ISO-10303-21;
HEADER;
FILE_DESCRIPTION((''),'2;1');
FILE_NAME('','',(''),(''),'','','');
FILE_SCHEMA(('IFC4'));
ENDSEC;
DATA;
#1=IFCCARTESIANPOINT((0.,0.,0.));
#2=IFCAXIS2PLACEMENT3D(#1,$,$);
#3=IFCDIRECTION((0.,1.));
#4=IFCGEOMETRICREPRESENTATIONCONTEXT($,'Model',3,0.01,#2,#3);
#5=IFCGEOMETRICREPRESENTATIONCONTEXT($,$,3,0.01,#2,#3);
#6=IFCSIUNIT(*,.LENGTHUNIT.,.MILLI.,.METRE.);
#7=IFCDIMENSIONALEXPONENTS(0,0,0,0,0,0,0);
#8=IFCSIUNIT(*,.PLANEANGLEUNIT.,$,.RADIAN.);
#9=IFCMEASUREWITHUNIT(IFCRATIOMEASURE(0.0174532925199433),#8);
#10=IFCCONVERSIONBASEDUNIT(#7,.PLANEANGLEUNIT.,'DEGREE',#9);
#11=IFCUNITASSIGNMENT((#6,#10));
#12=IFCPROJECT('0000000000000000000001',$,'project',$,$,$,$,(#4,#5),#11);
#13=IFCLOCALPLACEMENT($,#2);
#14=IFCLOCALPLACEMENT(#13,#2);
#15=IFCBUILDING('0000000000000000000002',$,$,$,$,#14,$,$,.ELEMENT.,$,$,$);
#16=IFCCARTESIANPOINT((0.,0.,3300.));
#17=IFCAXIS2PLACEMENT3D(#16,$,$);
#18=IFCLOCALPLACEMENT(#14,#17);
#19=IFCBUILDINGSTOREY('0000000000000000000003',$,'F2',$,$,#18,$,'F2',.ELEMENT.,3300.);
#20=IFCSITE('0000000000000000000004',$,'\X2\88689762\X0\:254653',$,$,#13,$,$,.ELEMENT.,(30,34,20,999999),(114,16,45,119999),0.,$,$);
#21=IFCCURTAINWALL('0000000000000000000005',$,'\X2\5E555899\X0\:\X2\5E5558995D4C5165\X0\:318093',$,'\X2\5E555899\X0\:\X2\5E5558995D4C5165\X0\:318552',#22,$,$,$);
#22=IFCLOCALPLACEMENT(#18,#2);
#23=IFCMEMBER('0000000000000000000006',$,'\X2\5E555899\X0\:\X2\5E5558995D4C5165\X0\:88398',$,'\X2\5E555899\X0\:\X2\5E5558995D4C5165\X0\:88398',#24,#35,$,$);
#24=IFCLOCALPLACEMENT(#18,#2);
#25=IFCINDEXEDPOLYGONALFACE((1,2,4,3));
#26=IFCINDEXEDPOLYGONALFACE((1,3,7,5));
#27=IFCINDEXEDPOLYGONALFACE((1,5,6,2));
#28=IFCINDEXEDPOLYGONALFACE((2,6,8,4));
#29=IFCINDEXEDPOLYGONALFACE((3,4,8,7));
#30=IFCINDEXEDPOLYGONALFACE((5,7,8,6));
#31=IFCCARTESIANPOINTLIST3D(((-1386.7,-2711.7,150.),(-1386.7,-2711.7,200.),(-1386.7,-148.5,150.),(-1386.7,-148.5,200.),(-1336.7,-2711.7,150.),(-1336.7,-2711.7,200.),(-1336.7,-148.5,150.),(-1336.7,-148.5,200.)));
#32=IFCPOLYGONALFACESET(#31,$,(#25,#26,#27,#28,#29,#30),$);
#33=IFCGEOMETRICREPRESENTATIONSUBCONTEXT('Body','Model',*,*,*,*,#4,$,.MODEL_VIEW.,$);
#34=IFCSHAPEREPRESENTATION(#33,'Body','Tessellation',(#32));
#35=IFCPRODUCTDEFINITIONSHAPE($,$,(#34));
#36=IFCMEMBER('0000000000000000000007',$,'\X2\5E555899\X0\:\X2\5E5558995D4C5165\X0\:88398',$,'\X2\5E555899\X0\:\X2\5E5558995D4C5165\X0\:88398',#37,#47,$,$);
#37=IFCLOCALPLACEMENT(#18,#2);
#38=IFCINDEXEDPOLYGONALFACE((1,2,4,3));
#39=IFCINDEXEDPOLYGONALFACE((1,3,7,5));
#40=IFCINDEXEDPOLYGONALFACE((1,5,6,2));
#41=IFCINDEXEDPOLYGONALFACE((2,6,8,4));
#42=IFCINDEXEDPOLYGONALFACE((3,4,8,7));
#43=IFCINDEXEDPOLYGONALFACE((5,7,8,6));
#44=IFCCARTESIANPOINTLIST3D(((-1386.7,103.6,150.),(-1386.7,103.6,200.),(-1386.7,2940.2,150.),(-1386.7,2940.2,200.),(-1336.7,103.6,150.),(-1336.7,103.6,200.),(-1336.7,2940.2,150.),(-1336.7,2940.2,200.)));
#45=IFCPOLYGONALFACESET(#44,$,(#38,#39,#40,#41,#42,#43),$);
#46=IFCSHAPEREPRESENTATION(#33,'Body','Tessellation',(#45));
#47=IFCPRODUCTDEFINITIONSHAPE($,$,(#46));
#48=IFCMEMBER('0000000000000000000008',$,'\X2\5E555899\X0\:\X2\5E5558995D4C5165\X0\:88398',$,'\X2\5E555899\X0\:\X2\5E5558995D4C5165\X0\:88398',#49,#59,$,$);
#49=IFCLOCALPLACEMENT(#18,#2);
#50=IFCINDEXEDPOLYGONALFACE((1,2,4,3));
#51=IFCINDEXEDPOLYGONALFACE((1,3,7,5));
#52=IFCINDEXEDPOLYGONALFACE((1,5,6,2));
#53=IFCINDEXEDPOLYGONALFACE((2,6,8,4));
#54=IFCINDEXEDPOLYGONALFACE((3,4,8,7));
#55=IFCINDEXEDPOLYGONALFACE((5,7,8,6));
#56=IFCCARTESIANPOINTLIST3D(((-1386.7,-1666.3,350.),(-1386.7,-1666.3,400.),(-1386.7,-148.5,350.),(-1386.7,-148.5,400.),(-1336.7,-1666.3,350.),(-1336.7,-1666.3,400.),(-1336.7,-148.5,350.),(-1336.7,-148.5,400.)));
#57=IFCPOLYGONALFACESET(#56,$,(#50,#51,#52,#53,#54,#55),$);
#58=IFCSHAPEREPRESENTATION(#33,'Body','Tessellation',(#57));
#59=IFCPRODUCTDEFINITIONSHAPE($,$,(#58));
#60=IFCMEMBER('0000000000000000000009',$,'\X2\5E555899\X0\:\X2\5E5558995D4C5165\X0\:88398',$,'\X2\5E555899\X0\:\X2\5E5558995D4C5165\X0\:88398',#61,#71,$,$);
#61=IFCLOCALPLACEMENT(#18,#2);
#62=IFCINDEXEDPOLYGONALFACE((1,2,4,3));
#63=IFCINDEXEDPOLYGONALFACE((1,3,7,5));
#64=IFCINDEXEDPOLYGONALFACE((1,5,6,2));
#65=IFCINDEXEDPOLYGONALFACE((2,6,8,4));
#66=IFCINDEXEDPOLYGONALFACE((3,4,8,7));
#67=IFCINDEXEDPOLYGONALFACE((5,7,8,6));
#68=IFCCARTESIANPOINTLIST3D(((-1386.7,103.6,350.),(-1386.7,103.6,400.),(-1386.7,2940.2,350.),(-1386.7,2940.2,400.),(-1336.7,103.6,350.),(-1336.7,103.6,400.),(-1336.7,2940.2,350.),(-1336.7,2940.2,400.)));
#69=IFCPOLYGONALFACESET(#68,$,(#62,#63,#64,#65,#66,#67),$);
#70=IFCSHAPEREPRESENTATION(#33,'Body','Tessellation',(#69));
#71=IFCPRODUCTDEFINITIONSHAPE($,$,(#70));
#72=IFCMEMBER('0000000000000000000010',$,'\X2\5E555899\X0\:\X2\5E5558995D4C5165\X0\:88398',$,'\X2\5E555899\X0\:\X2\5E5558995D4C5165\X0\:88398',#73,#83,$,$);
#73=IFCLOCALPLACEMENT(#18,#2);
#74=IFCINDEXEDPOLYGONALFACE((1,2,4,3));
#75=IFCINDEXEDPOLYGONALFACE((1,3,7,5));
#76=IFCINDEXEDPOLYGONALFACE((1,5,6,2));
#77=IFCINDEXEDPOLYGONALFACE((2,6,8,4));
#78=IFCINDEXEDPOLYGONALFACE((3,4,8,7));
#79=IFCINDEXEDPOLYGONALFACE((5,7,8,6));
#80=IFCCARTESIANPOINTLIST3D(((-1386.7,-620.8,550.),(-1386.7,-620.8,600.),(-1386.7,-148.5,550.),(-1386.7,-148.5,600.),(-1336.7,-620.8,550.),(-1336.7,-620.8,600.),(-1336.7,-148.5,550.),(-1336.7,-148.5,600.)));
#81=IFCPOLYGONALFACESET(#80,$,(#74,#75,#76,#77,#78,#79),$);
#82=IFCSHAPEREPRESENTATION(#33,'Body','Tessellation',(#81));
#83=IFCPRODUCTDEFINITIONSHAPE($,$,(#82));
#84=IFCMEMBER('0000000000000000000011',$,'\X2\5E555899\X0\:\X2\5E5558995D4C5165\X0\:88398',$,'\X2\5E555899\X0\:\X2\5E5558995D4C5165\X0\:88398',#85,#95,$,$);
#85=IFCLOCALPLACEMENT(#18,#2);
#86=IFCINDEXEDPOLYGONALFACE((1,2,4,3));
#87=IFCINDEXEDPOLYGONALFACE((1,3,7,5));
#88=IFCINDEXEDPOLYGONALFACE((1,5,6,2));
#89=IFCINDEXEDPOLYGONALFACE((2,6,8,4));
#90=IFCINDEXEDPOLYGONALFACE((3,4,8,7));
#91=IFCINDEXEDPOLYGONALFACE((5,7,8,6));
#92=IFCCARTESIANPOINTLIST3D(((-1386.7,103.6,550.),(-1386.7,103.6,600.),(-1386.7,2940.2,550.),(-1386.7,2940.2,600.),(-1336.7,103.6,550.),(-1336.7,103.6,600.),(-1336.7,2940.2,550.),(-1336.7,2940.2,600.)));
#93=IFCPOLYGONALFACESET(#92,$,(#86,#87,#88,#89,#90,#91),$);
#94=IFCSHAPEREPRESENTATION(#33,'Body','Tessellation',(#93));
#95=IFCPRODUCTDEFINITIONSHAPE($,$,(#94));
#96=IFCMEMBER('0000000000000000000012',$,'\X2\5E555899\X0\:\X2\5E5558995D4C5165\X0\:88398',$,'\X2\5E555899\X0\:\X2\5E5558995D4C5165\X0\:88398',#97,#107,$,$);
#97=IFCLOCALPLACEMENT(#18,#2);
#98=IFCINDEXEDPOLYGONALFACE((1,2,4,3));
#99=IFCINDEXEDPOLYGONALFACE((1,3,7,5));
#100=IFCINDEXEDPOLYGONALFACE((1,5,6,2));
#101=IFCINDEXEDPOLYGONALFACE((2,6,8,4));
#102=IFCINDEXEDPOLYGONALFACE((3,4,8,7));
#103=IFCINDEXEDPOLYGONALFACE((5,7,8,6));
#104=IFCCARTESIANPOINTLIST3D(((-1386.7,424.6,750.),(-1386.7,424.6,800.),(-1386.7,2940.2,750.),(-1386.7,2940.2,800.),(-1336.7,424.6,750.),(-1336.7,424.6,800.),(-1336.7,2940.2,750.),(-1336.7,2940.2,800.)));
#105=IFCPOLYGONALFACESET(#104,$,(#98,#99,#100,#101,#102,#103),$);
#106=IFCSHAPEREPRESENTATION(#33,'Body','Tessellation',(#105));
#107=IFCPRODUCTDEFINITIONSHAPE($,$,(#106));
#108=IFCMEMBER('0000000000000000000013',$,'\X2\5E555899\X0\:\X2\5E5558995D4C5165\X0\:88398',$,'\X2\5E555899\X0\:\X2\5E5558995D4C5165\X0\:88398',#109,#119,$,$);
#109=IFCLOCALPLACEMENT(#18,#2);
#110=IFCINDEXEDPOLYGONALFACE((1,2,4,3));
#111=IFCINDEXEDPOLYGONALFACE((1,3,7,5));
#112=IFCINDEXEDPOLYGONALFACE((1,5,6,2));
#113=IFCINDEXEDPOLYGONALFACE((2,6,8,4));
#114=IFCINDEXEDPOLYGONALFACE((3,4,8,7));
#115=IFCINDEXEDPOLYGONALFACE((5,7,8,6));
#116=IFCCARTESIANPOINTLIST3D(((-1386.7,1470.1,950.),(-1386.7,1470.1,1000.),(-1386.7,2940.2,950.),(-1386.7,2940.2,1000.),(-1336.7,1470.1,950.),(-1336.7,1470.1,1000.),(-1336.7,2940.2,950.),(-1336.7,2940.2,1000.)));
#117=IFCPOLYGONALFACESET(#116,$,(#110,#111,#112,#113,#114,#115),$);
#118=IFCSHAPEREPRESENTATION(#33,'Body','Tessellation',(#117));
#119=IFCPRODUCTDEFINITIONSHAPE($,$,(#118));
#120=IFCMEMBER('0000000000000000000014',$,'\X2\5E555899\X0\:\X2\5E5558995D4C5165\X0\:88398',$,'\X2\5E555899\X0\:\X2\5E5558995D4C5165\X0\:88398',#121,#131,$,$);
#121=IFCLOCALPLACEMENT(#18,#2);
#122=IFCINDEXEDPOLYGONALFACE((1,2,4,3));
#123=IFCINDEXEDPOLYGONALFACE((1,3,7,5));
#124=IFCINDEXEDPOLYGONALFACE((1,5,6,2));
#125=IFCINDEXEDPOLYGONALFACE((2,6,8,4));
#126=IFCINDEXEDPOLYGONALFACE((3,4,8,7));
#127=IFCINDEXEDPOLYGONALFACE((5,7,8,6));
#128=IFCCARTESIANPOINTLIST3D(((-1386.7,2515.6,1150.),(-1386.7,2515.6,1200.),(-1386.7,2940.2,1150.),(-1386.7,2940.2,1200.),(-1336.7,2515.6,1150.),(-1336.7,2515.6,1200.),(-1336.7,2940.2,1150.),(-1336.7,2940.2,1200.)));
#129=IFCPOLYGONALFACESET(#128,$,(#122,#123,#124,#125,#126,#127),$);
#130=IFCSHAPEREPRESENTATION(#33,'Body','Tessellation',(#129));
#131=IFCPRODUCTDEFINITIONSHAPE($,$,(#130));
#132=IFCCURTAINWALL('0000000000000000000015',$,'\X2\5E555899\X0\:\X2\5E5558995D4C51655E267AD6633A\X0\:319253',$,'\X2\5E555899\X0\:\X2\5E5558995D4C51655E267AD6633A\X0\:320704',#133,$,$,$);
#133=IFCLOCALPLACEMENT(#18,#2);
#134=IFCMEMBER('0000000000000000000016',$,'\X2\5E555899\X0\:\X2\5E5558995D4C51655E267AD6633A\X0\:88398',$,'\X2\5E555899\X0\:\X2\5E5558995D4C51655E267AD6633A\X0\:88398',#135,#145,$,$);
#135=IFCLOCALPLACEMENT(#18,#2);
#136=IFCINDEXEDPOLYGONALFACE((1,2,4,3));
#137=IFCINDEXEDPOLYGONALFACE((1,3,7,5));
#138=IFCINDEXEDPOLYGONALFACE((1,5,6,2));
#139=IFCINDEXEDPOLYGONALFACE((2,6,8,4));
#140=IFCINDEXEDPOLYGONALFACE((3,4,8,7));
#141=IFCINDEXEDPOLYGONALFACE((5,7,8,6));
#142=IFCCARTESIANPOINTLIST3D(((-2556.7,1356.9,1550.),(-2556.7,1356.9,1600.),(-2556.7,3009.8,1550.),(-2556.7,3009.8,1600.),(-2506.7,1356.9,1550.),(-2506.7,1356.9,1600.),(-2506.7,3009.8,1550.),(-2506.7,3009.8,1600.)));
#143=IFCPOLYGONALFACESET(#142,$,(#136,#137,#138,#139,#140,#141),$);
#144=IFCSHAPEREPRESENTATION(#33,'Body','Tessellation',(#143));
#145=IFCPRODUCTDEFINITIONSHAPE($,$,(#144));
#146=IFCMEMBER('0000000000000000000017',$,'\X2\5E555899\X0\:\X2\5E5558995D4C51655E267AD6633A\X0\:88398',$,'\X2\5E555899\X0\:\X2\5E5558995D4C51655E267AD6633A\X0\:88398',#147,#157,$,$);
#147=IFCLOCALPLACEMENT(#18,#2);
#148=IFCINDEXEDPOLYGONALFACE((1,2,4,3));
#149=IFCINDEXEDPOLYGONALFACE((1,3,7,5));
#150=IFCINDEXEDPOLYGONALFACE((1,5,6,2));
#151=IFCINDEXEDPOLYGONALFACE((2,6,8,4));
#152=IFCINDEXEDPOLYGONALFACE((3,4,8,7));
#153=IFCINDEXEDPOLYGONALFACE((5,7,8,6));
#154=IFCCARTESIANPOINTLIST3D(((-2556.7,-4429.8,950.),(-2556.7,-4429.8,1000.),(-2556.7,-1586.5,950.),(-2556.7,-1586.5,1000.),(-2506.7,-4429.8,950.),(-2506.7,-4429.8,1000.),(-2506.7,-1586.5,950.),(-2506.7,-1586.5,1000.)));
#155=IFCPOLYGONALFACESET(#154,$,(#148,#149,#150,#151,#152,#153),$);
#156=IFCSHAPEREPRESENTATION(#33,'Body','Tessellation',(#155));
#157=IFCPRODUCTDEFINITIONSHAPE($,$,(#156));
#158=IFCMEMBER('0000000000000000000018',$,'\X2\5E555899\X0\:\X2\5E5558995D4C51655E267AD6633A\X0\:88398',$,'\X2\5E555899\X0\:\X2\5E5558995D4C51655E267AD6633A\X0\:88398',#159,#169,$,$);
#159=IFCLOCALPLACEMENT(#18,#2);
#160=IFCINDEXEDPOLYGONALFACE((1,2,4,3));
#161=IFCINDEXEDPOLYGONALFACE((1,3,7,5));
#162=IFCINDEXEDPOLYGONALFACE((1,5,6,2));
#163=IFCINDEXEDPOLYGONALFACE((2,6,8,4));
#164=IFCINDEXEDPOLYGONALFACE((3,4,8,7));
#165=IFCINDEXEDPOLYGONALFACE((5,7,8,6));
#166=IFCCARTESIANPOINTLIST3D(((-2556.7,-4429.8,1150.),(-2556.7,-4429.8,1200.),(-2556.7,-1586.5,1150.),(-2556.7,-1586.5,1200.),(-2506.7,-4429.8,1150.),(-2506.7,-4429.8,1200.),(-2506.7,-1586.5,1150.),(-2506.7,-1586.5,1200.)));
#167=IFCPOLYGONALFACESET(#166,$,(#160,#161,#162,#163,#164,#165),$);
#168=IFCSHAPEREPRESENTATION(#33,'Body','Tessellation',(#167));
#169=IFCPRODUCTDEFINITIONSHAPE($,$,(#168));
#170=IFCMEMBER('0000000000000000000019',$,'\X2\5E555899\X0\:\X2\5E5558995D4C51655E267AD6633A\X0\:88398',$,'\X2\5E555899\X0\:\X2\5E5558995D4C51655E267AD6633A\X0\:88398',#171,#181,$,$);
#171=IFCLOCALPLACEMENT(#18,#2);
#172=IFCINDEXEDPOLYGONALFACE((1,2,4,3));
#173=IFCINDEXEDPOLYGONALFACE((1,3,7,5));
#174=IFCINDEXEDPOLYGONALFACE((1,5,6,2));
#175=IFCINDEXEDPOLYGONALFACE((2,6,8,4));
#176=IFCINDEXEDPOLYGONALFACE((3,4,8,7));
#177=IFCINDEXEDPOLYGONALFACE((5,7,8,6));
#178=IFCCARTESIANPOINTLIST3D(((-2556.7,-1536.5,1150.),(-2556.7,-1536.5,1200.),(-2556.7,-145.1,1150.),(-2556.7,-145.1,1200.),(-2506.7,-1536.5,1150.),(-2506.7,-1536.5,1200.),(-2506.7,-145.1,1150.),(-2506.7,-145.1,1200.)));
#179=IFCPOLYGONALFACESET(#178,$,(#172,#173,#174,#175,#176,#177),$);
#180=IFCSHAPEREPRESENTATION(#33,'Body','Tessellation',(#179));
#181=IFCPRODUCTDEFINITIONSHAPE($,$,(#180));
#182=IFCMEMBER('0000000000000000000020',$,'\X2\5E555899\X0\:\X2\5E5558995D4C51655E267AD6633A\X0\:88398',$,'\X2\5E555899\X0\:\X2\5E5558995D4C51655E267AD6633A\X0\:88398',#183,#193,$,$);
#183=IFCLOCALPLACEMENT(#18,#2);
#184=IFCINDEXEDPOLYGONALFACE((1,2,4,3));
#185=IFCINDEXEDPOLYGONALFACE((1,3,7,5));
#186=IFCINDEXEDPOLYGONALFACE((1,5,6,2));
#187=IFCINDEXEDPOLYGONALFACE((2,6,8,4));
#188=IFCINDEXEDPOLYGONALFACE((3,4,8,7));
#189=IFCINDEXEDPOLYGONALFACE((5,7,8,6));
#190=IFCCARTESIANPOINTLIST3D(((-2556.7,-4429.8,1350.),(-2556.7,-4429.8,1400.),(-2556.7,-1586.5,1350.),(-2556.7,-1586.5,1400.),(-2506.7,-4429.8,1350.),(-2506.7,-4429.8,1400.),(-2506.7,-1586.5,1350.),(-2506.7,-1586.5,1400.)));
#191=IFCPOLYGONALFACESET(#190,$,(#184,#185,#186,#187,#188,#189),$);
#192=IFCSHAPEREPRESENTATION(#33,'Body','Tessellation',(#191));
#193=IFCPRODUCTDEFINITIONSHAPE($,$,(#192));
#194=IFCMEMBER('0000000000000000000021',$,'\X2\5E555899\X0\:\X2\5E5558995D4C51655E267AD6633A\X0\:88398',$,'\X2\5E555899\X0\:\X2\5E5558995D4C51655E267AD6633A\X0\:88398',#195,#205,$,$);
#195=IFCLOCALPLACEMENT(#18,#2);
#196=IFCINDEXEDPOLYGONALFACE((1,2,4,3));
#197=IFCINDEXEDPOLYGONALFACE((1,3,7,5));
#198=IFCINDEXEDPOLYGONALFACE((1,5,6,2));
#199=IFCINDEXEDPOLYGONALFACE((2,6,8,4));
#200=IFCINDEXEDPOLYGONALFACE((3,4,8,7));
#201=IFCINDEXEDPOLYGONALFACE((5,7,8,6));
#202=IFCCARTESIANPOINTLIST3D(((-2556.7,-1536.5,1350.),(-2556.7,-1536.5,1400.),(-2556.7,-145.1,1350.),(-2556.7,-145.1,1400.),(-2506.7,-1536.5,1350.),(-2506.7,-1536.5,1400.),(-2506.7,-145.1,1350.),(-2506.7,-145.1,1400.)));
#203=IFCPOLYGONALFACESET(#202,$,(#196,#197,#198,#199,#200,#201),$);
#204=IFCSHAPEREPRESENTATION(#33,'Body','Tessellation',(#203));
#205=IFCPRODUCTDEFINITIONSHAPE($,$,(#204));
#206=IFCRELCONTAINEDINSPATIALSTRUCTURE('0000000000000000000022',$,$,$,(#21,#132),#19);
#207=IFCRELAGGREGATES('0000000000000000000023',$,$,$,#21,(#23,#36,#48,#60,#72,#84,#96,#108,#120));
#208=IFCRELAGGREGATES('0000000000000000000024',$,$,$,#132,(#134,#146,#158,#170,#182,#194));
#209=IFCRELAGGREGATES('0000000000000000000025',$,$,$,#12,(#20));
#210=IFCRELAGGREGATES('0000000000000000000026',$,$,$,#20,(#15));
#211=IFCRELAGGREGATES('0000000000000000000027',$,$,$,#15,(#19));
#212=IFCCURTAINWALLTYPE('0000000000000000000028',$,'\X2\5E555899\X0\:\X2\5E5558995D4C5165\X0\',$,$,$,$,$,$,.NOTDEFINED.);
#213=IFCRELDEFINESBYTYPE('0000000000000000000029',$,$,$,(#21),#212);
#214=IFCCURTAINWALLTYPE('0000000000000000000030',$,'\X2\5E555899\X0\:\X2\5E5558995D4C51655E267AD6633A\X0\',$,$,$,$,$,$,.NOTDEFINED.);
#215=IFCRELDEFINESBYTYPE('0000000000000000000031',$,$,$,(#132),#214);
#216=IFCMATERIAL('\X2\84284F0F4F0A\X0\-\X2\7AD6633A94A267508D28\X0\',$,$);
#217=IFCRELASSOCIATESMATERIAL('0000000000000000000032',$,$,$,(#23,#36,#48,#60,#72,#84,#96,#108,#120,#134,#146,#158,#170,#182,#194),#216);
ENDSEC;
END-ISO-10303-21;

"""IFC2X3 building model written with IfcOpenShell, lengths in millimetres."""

from ifc_helpers import new_model, entity, si_unit, converted_unit, direction, frame, frame_2d, origin, origin_2d_with_axis, place, context, subcontext, project, spatial, rectangle, extrude, material, type_object, element, aggregate, save


model = new_model("IFC2X3")

# Units and contexts
model_context = context("Model", 3, precision=0.01, world=origin(), true_north=direction((0.0, 1.0)))
context_of_model = context(None, 3, precision=0.01, world=origin(), true_north=direction((0.0, 1.0)))
body_context = subcontext(model_context, "Body", "Model", "MODEL_VIEW")
ifc_project = project(units=[si_unit("LENGTHUNIT", "METRE", prefix="MILLI"), converted_unit("PLANEANGLEUNIT", "DEGREE", entity("IfcRatioMeasure", 0.0174532925199433), si_unit("PLANEANGLEUNIT", "RADIAN"), dimensions=[0, 0, 0, 0, 0, 0, 0])], contexts=[model_context, context_of_model])

# Site, building, storey
site_placement = place(None, origin())
site = spatial("IfcSite", under=ifc_project, at=site_placement, Name="表面:254653", CompositionType="ELEMENT", RefLatitude=(30, 34, 20, 999999), RefLongitude=(114, 16, 45, 119999), RefElevation=0.0)
building_placement = place(site_placement, origin())
building = spatial("IfcBuilding", under=site, at=building_placement, CompositionType="ELEMENT")
storey_placement = place(building_placement, frame((0.0, 0.0, 3300.0)))
storey = spatial("IfcBuildingStorey", under=building, at=storey_placement, Name="F2", LongName="F2", CompositionType="ELEMENT", Elevation=3300.0)

# Curtain wall, members
curtain_wall_type_1 = type_object("IfcCurtainWallType", Name="幕墙:幕墙嵌入", PredefinedType="NOTDEFINED")
curtain_wall_1_placement = place(storey_placement, frame((0.0, 0.0, -3300.0)))
curtain_wall_1 = element("IfcCurtainWall", 1, at=curtain_wall_1_placement, inside=storey, type_object=curtain_wall_type_1, Name="幕墙:幕墙嵌入:318093", ObjectType="幕墙:幕墙嵌入:318552")
ifc_material_1 = material(Name="萨伏伊-竖挺钢材质")
member_1_placement = place(curtain_wall_1_placement, frame((0.0, 0.0, 3300.0)))
member_1 = element("IfcMember", 2, at=member_1_placement, material=ifc_material_1, Name="幕墙:幕墙嵌入:88398", ObjectType="幕墙:幕墙嵌入:88398", context=body_context, shape_type="SweptSolid", body=[
    extrude(rectangle(XDim=50.0, YDim=50.0, at=origin_2d_with_axis()), frame((-1361.7, -2711.7, 175.0), z_axis=(0.0, 1.0, 0.0), x_axis=(0.0, 0.0, -1.0)), (0.0, 0.0, 1.0), 2563.2),
])
member_2_placement = place(curtain_wall_1_placement, frame((0.0, 0.0, 3300.0)))
member_2 = element("IfcMember", 3, at=member_2_placement, material=ifc_material_1, Name="幕墙:幕墙嵌入:88398", ObjectType="幕墙:幕墙嵌入:88398", context=body_context, shape_type="SweptSolid", body=[
    extrude(rectangle(XDim=50.0, YDim=50.0, at=origin_2d_with_axis()), frame((-1361.7, 103.6, 175.0), z_axis=(0.0, 1.0, 0.0), x_axis=(0.0, 0.0, -1.0)), (0.0, 0.0, 1.0), 2836.6),
])
member_3_placement = place(curtain_wall_1_placement, frame((0.0, 0.0, 3300.0)))
member_3 = element("IfcMember", 4, at=member_3_placement, material=ifc_material_1, Name="幕墙:幕墙嵌入:88398", ObjectType="幕墙:幕墙嵌入:88398", context=body_context, shape_type="SweptSolid", body=[
    extrude(rectangle(XDim=50.0, YDim=50.0, at=origin_2d_with_axis()), frame((-1361.7, -1666.3, 375.0), z_axis=(0.0, 1.0, 0.0), x_axis=(0.0, 0.0, -1.0)), (0.0, 0.0, 1.0), 1517.7),
])
member_4_placement = place(curtain_wall_1_placement, frame((0.0, 0.0, 3300.0)))
member_4 = element("IfcMember", 5, at=member_4_placement, material=ifc_material_1, Name="幕墙:幕墙嵌入:88398", ObjectType="幕墙:幕墙嵌入:88398", context=body_context, shape_type="SweptSolid", body=[
    extrude(rectangle(XDim=50.0, YDim=50.0, at=origin_2d_with_axis()), frame((-1361.7, 103.6, 375.0), z_axis=(0.0, 1.0, 0.0), x_axis=(0.0, 0.0, -1.0)), (0.0, 0.0, 1.0), 2836.6),
])
member_5_placement = place(curtain_wall_1_placement, frame((0.0, 0.0, 3300.0)))
member_5 = element("IfcMember", 6, at=member_5_placement, material=ifc_material_1, Name="幕墙:幕墙嵌入:88398", ObjectType="幕墙:幕墙嵌入:88398", context=body_context, shape_type="SweptSolid", body=[
    extrude(rectangle(XDim=50.0, YDim=50.0, at=origin_2d_with_axis()), frame((-1361.7, -620.8, 575.0), z_axis=(0.0, 1.0, 0.0), x_axis=(0.0, 0.0, -1.0)), (0.0, 0.0, 1.0), 472.3),
])
member_6_placement = place(curtain_wall_1_placement, frame((0.0, 0.0, 3300.0)))
member_6 = element("IfcMember", 7, at=member_6_placement, material=ifc_material_1, Name="幕墙:幕墙嵌入:88398", ObjectType="幕墙:幕墙嵌入:88398", context=body_context, shape_type="SweptSolid", body=[
    extrude(rectangle(XDim=50.0, YDim=50.0, at=origin_2d_with_axis()), frame((-1361.7, 103.6, 575.0), z_axis=(0.0, 1.0, 0.0), x_axis=(0.0, 0.0, -1.0)), (0.0, 0.0, 1.0), 2836.6),
])
member_7_placement = place(curtain_wall_1_placement, frame((0.0, 0.0, 3300.0)))
member_7 = element("IfcMember", 8, at=member_7_placement, material=ifc_material_1, Name="幕墙:幕墙嵌入:88398", ObjectType="幕墙:幕墙嵌入:88398", context=body_context, shape_type="SweptSolid", body=[
    extrude(rectangle(XDim=50.0, YDim=50.0, at=origin_2d_with_axis()), frame((-1361.7, 424.6, 775.0), z_axis=(0.0, 1.0, 0.0), x_axis=(0.0, 0.0, -1.0)), (0.0, 0.0, 1.0), 2515.6),
])
member_8_placement = place(curtain_wall_1_placement, frame((0.0, 0.0, 3300.0)))
member_8 = element("IfcMember", 9, at=member_8_placement, material=ifc_material_1, Name="幕墙:幕墙嵌入:88398", ObjectType="幕墙:幕墙嵌入:88398", context=body_context, shape_type="SweptSolid", body=[
    extrude(rectangle(XDim=50.0, YDim=50.0, at=origin_2d_with_axis()), frame((-1361.7, 1470.1, 975.0), z_axis=(0.0, 1.0, 0.0), x_axis=(0.0, 0.0, -1.0)), (0.0, 0.0, 1.0), 1470.1),
])
member_9_placement = place(curtain_wall_1_placement, frame((0.0, 0.0, 3300.0)))
member_9 = element("IfcMember", 10, at=member_9_placement, material=ifc_material_1, Name="幕墙:幕墙嵌入:88398", ObjectType="幕墙:幕墙嵌入:88398", context=body_context, shape_type="SweptSolid", body=[
    extrude(rectangle(XDim=50.0, YDim=50.0, at=origin_2d_with_axis()), frame((-1361.7, 2515.6, 1175.0), z_axis=(0.0, 1.0, 0.0), x_axis=(0.0, 0.0, -1.0)), (0.0, 0.0, 1.0), 424.6),
])
aggregate(curtain_wall_1, [member_1, member_2, member_3, member_4, member_5, member_6, member_7, member_8, member_9])

# Curtain wall, members
curtain_wall_type_2 = type_object("IfcCurtainWallType", Name="幕墙:幕墙嵌入带竖挺", PredefinedType="NOTDEFINED")
curtain_wall_2_placement = place(storey_placement, frame((0.0, 0.0, -3300.0)))
curtain_wall_2 = element("IfcCurtainWall", 11, at=curtain_wall_2_placement, inside=storey, type_object=curtain_wall_type_2, Name="幕墙:幕墙嵌入带竖挺:319253", ObjectType="幕墙:幕墙嵌入带竖挺:320704")
member_10_placement = place(curtain_wall_2_placement, frame((0.0, 0.0, 3300.0)))
member_10 = element("IfcMember", 12, at=member_10_placement, material=ifc_material_1, Name="幕墙:幕墙嵌入带竖挺:88398", ObjectType="幕墙:幕墙嵌入带竖挺:88398", context=body_context, shape_type="SweptSolid", body=[
    extrude(rectangle(XDim=50.0, YDim=50.0, at=origin_2d_with_axis()), frame((-2531.7, 1356.9, 1575.0), z_axis=(0.0, 1.0, 0.0), x_axis=(0.0, 0.0, -1.0)), (0.0, 0.0, 1.0), 1653.0),
])
member_11_placement = place(curtain_wall_2_placement, frame((0.0, 0.0, 3300.0)))
member_11 = element("IfcMember", 13, at=member_11_placement, material=ifc_material_1, Name="幕墙:幕墙嵌入带竖挺:88398", ObjectType="幕墙:幕墙嵌入带竖挺:88398", context=body_context, shape_type="SweptSolid", body=[
    extrude(rectangle(XDim=50.0, YDim=50.0, at=origin_2d_with_axis()), frame((-2531.7, -4429.8, 975.0), z_axis=(0.0, 1.0, 0.0), x_axis=(0.0, 0.0, -1.0)), (0.0, 0.0, 1.0), 2843.3),
])
member_12_placement = place(curtain_wall_2_placement, frame((0.0, 0.0, 3300.0)))
member_12 = element("IfcMember", 14, at=member_12_placement, material=ifc_material_1, Name="幕墙:幕墙嵌入带竖挺:88398", ObjectType="幕墙:幕墙嵌入带竖挺:88398", context=body_context, shape_type="SweptSolid", body=[
    extrude(rectangle(XDim=50.0, YDim=50.0, at=origin_2d_with_axis()), frame((-2531.7, -4429.8, 1175.0), z_axis=(0.0, 1.0, 0.0), x_axis=(0.0, 0.0, -1.0)), (0.0, 0.0, 1.0), 2843.3),
])
member_13_placement = place(curtain_wall_2_placement, frame((0.0, 0.0, 3300.0)))
member_13 = element("IfcMember", 15, at=member_13_placement, material=ifc_material_1, Name="幕墙:幕墙嵌入带竖挺:88398", ObjectType="幕墙:幕墙嵌入带竖挺:88398", context=body_context, shape_type="SweptSolid", body=[
    extrude(rectangle(XDim=50.0, YDim=50.0, at=frame_2d((0.0, 0.0), x_axis=(1.0, 0.0))), frame((-2531.7, -1536.5, 1175.0), z_axis=(0.0, 1.0, 0.0), x_axis=(0.0, 0.0, -1.0)), (0.0, 0.0, 1.0), 1391.3),
])
member_14_placement = place(curtain_wall_2_placement, frame((0.0, 0.0, 3300.0)))
member_14 = element("IfcMember", 16, at=member_14_placement, material=ifc_material_1, Name="幕墙:幕墙嵌入带竖挺:88398", ObjectType="幕墙:幕墙嵌入带竖挺:88398", context=body_context, shape_type="SweptSolid", body=[
    extrude(rectangle(XDim=50.0, YDim=50.0, at=origin_2d_with_axis()), frame((-2531.7, -4429.8, 1375.0), z_axis=(0.0, 1.0, 0.0), x_axis=(0.0, 0.0, -1.0)), (0.0, 0.0, 1.0), 2843.3),
])
member_15_placement = place(curtain_wall_2_placement, frame((0.0, 0.0, 3300.0)))
member_15 = element("IfcMember", 17, at=member_15_placement, material=ifc_material_1, Name="幕墙:幕墙嵌入带竖挺:88398", ObjectType="幕墙:幕墙嵌入带竖挺:88398", context=body_context, shape_type="SweptSolid", body=[
    extrude(rectangle(XDim=50.0, YDim=50.0, at=frame_2d((0.0, 0.0), x_axis=(1.0, 0.0))), frame((-2531.7, -1536.5, 1375.0), z_axis=(0.0, 1.0, 0.0), x_axis=(0.0, 0.0, -1.0)), (0.0, 0.0, 1.0), 1391.3),
])
aggregate(curtain_wall_2, [member_10, member_11, member_12, member_13, member_14, member_15])

save(model, "model.ifc")
